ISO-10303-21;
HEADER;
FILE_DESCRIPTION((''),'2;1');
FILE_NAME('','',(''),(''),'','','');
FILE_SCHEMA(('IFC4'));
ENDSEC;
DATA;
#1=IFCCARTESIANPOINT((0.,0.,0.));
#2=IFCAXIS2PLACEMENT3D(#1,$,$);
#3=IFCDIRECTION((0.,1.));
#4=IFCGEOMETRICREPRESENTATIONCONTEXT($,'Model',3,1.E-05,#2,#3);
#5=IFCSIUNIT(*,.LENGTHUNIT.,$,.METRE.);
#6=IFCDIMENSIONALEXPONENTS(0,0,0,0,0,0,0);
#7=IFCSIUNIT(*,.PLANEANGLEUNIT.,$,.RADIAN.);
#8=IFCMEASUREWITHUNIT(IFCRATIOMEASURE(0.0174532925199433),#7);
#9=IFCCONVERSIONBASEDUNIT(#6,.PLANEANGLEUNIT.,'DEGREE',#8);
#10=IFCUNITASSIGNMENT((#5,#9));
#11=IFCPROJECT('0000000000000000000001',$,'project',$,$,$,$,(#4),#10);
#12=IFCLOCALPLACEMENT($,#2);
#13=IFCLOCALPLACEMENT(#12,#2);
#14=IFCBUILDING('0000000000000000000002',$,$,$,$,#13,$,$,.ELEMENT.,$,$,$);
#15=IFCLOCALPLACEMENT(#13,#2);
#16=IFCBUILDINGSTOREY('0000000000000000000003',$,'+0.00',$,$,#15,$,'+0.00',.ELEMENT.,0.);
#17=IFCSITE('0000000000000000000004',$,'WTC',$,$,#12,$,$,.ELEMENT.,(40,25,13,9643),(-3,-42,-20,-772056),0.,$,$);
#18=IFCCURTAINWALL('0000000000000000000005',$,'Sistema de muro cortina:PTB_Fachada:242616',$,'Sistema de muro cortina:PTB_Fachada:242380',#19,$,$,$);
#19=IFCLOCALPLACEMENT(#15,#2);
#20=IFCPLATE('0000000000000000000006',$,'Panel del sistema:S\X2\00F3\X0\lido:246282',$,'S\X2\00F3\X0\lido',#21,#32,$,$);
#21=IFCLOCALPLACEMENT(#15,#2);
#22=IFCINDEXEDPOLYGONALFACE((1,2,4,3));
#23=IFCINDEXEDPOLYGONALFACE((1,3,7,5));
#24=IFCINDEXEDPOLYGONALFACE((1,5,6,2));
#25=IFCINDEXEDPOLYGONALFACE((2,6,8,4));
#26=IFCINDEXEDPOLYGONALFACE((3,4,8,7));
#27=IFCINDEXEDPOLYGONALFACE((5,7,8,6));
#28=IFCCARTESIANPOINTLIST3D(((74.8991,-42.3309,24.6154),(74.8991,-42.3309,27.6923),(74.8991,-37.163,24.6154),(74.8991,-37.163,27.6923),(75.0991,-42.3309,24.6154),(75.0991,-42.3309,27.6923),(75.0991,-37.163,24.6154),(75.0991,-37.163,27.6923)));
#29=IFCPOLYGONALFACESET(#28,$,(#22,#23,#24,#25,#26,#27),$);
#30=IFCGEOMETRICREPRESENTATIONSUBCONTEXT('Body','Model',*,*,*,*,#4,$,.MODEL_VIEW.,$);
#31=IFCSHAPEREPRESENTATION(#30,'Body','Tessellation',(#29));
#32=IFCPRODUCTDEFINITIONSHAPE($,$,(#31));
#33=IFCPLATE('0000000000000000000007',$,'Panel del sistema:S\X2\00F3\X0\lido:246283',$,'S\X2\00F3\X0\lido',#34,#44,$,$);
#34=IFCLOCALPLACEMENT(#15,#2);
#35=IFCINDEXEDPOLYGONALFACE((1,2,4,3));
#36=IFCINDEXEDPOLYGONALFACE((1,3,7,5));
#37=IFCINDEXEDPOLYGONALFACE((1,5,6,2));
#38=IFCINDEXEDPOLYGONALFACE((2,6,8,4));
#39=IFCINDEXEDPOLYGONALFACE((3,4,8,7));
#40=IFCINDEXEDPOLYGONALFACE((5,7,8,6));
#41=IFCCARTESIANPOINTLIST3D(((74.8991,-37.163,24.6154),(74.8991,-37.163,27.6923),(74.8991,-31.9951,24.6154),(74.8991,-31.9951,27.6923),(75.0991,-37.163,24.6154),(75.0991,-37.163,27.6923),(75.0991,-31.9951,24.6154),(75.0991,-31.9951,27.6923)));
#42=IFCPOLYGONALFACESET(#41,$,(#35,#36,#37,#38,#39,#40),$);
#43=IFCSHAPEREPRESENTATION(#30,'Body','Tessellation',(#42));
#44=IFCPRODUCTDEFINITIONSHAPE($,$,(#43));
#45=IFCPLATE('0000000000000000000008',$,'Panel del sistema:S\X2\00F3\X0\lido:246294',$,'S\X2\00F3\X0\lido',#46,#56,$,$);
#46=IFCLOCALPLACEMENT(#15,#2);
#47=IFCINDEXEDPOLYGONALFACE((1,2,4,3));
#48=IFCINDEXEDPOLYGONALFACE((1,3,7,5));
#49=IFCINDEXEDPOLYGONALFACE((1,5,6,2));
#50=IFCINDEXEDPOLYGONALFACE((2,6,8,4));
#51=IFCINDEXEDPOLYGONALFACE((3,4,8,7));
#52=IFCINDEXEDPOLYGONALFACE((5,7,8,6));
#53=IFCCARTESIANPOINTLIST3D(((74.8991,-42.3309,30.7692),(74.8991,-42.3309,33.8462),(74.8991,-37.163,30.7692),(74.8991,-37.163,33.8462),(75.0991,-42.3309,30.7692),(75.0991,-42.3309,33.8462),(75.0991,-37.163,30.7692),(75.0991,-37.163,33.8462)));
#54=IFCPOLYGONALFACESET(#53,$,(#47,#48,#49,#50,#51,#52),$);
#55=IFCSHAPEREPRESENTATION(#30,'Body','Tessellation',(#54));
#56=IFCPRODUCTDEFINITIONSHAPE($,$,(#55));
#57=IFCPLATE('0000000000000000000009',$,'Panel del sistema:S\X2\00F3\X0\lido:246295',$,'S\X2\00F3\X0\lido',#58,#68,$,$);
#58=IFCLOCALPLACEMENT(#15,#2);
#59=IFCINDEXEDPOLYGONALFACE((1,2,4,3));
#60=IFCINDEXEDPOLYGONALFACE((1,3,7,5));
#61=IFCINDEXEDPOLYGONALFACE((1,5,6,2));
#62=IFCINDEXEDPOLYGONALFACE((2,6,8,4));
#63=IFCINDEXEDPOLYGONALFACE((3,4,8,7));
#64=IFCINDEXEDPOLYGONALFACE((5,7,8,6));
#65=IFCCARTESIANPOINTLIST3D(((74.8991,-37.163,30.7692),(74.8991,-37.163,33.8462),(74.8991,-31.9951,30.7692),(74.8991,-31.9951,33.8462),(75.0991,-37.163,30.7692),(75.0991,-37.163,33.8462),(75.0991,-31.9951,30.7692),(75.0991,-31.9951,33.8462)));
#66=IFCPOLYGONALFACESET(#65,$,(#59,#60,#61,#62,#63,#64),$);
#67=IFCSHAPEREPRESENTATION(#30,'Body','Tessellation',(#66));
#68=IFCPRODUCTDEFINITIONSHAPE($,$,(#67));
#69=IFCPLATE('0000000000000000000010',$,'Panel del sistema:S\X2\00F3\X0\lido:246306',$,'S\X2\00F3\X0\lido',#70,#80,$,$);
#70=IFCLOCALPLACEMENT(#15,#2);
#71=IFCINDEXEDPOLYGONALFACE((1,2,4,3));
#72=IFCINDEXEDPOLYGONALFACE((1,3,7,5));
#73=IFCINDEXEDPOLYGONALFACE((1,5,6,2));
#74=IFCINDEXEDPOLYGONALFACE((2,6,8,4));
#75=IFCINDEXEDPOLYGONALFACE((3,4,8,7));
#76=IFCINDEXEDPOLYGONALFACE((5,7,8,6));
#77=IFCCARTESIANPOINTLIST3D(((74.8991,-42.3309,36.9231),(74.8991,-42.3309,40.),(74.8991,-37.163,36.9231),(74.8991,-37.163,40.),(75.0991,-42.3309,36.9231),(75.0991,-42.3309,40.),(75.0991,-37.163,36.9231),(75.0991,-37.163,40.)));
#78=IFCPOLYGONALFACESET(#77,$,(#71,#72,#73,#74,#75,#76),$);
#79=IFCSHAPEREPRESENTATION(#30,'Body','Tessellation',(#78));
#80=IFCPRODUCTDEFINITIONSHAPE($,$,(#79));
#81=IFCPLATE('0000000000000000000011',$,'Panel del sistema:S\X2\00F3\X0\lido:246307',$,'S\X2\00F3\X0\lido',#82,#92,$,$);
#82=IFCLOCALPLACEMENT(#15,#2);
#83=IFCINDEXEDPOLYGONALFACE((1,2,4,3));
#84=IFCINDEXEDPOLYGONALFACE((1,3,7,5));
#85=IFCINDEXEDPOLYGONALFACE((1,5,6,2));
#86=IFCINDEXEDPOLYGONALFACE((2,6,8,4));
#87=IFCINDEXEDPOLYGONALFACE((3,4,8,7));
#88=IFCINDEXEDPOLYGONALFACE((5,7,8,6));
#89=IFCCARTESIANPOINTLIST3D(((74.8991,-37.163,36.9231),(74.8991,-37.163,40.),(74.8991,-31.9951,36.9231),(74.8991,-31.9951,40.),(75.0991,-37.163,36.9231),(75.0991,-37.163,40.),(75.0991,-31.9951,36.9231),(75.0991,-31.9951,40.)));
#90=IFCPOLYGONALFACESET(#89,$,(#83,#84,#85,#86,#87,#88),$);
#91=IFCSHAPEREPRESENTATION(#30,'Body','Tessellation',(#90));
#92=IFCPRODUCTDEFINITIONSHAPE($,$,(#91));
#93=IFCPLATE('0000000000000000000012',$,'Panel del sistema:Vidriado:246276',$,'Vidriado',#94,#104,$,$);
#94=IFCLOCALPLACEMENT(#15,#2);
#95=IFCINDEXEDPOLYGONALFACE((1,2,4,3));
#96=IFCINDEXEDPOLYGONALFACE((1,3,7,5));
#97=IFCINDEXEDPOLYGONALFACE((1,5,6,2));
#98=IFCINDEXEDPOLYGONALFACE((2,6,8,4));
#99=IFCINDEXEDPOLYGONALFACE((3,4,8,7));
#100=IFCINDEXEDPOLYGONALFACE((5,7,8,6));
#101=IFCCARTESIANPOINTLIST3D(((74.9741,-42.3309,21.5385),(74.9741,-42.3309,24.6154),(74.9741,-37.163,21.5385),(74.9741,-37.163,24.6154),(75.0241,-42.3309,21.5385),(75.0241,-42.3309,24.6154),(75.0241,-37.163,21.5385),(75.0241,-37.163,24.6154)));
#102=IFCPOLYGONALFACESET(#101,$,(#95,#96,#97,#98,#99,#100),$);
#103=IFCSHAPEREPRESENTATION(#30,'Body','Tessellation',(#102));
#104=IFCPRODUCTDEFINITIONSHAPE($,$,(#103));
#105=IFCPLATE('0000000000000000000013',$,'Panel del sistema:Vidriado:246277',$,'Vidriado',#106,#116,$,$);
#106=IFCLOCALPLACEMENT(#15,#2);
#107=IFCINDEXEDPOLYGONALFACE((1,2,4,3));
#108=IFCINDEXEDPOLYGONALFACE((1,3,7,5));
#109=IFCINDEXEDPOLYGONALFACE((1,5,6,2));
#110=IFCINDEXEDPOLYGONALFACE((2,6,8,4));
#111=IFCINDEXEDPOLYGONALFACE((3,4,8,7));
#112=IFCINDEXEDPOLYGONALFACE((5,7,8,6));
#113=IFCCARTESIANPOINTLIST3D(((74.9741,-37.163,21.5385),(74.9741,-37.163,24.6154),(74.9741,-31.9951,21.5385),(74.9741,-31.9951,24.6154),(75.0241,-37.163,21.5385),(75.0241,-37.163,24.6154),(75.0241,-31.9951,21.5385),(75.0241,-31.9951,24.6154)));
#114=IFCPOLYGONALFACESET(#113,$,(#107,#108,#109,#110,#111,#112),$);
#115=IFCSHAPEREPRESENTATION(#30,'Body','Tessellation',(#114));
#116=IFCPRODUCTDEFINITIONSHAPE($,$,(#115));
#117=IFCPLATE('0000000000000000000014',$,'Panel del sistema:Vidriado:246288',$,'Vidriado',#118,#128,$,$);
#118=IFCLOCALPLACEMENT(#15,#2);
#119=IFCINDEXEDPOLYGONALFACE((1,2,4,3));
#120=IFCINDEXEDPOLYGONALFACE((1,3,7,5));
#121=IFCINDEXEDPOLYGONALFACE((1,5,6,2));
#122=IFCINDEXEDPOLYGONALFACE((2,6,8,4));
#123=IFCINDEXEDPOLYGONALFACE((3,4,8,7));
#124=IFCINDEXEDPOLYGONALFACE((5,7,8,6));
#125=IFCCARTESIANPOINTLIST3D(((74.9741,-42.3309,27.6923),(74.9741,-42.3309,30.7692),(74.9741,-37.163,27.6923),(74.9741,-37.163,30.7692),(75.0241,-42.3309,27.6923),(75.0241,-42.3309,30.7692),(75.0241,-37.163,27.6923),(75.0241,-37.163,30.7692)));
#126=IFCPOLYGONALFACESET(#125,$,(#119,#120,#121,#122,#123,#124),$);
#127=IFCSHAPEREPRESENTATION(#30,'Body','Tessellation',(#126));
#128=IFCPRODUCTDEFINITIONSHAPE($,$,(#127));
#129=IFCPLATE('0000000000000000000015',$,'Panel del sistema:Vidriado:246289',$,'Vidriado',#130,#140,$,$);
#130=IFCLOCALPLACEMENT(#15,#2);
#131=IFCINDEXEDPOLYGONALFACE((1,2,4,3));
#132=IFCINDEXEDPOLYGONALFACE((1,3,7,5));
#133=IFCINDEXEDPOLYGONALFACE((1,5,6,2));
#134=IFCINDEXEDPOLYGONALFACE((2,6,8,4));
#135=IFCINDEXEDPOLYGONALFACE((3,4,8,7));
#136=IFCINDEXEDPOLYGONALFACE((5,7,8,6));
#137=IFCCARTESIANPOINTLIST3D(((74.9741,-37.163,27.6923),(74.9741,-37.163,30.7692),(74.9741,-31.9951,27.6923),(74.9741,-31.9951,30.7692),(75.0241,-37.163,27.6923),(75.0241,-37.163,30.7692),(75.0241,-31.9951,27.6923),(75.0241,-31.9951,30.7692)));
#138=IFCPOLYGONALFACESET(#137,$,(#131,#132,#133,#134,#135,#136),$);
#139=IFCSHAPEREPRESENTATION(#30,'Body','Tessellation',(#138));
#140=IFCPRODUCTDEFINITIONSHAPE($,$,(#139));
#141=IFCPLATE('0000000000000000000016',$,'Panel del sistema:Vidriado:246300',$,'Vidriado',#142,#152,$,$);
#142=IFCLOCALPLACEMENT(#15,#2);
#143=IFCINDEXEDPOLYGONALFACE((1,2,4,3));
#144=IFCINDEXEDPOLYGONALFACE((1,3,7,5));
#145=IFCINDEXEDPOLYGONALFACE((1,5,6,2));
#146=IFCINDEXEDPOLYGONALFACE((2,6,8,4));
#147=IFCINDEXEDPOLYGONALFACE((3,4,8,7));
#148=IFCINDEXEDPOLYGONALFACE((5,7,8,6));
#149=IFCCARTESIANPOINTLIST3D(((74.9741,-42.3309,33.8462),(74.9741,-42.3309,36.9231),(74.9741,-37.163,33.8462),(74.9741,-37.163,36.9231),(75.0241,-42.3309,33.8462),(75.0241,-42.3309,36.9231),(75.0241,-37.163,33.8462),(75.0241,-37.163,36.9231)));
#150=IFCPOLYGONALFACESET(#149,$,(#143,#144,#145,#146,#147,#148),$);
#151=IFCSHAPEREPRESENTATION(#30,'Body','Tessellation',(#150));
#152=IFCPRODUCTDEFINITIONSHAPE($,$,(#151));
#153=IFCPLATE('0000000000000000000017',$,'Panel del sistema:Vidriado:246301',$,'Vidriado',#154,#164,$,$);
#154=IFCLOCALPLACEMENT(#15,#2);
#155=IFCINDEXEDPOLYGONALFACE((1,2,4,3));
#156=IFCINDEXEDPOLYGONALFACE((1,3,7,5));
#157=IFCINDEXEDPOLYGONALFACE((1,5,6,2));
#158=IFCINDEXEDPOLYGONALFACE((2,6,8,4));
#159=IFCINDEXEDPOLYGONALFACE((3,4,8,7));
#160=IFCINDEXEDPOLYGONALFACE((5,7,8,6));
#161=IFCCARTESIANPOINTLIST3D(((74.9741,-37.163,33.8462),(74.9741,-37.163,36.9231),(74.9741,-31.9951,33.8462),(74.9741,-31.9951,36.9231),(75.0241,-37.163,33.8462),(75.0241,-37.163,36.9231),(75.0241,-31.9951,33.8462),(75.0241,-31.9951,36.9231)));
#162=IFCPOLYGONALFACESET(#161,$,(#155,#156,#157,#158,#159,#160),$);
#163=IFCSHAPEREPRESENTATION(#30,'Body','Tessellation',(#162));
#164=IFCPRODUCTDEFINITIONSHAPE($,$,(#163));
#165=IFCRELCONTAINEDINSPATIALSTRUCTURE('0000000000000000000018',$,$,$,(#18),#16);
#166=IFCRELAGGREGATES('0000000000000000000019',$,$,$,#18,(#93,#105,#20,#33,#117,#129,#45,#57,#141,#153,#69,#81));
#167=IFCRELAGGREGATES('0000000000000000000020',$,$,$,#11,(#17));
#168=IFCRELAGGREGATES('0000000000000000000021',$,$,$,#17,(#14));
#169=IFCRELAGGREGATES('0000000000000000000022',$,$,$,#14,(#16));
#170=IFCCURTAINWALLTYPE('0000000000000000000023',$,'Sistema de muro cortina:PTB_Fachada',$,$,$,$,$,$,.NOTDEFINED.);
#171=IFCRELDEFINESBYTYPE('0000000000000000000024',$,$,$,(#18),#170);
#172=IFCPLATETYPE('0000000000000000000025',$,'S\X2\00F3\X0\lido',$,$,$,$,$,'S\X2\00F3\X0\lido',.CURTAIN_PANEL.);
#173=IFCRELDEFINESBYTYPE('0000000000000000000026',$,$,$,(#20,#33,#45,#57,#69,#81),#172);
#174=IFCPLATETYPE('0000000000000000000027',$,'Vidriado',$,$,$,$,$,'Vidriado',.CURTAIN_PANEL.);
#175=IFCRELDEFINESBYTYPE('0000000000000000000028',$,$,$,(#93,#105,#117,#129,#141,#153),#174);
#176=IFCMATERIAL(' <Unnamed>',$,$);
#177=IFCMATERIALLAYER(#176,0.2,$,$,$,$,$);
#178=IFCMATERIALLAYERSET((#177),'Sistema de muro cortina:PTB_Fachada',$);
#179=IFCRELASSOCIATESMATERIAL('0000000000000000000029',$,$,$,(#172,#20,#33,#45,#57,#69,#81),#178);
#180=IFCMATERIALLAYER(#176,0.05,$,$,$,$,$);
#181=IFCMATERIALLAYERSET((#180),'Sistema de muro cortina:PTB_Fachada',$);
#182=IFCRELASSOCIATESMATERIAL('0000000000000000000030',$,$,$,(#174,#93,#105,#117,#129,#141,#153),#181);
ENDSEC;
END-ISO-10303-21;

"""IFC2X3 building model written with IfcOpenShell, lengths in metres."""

from ifc_helpers import new_model, entity, si_unit, converted_unit, direction, frame, origin, origin_2d_with_axis, place, context, subcontext, project, spatial, rectangle, extrude, source, transform, mapped, material, layer, layer_set, layer_usage, type_object, type_shapes, element, aggregate, save


model = new_model("IFC2X3")

# Units and contexts
model_context = context("Model", 3, precision=1e-05, world=origin(), true_north=direction((0.0, 1.0)))
body_context = subcontext(model_context, "Body", "Model", "MODEL_VIEW")
ifc_project = project(units=[si_unit("LENGTHUNIT", "METRE"), converted_unit("PLANEANGLEUNIT", "DEGREE", entity("IfcRatioMeasure", 0.0174532925199433), si_unit("PLANEANGLEUNIT", "RADIAN"), dimensions=[0, 0, 0, 0, 0, 0, 0])], contexts=[model_context])

# Site, building, storey
site_placement = place(None, origin())
site = spatial("IfcSite", under=ifc_project, at=site_placement, Name="WTC", CompositionType="ELEMENT", RefLatitude=(40, 25, 13, 9643), RefLongitude=(-3, -42, -20, -772056), RefElevation=0.0)
building_placement = place(site_placement, origin())
building = spatial("IfcBuilding", under=site, at=building_placement, CompositionType="ELEMENT")
storey_placement = place(building_placement, origin())
storey = spatial("IfcBuildingStorey", under=building, at=storey_placement, Name="+0.00", LongName="+0.00", CompositionType="ELEMENT", Elevation=0.0)

# Curtain wall, plates
curtain_wall_type = type_object("IfcCurtainWallType", Name="Sistema de muro cortina:PTB_Fachada", PredefinedType="NOTDEFINED")
ifc_material = material(Name=" <Unnamed>")
ifc_layer_1 = layer(ifc_material, 0.2)
ifc_layer_set_1 = layer_set([ifc_layer_1], Name="Sistema de muro cortina:PTB_Fachada")
ifc_layer_2 = layer(ifc_material, 0.05)
ifc_layer_set_2 = layer_set([ifc_layer_2], Name="Sistema de muro cortina:PTB_Fachada")
curtain_wall_1_placement = place(storey_placement, origin())
curtain_wall_1 = element("IfcCurtainWall", 1, at=curtain_wall_1_placement, inside=storey, type_object=curtain_wall_type, Name="Sistema de muro cortina:PTB_Fachada:242616", ObjectType="Sistema de muro cortina:PTB_Fachada:242380")
ifc_layer_usage_1 = layer_usage(ifc_layer_set_1, "AXIS3", "POSITIVE", 0.0)
plate_type_1 = type_object("IfcPlateType", Name="Sólido", ElementType="Sólido", PredefinedType="CURTAIN_PANEL", material=ifc_layer_set_1)
shared_shape_1 = source(origin(), body_context, "Body", "SweptSolid", [
    extrude(rectangle(XDim=0.2, YDim=5.1679, at=origin_2d_with_axis()), frame((0.0, 0.0, 0.0), z_axis=(0.0, 0.0, 1.0), x_axis=(0.0, 1.0, 0.0)), (0.0, 0.0, 1.0), 3.0769),
])
type_shapes(plate_type_1, [shared_shape_1])
plate_1_placement = place(curtain_wall_1_placement, frame((74.9991, -39.747, 24.6154), z_axis=(0.0, 0.0, 1.0), x_axis=(0.0, 1.0, 0.0)))
plate_1 = element("IfcPlate", 2, at=plate_1_placement, type_object=plate_type_1, material=ifc_layer_usage_1, Name="Panel del sistema:Sólido:246282", ObjectType="Sólido", context=body_context, shape_type="MappedRepresentation", body=[
    mapped(shared_shape_1, transform((0.0, 0.0, 0.0), scale=1.0)),
])
ifc_layer_usage_2 = layer_usage(ifc_layer_set_1, "AXIS3", "POSITIVE", 0.0)
plate_2_placement = place(curtain_wall_1_placement, frame((74.9991, -34.5791, 24.6154), z_axis=(0.0, 0.0, 1.0), x_axis=(0.0, 1.0, 0.0)))
plate_2 = element("IfcPlate", 3, at=plate_2_placement, type_object=plate_type_1, material=ifc_layer_usage_2, Name="Panel del sistema:Sólido:246283", ObjectType="Sólido", context=body_context, shape_type="MappedRepresentation", body=[
    mapped(shared_shape_1, transform((0.0, 0.0, 0.0), scale=1.0)),
])
ifc_layer_usage_3 = layer_usage(ifc_layer_set_1, "AXIS3", "POSITIVE", 0.0)
plate_3_placement = place(curtain_wall_1_placement, frame((74.9991, -39.747, 30.7692), z_axis=(0.0, 0.0, 1.0), x_axis=(0.0, 1.0, 0.0)))
plate_3 = element("IfcPlate", 4, at=plate_3_placement, type_object=plate_type_1, material=ifc_layer_usage_3, Name="Panel del sistema:Sólido:246294", ObjectType="Sólido", context=body_context, shape_type="MappedRepresentation", body=[
    mapped(shared_shape_1, transform((0.0, 0.0, 0.0), scale=1.0)),
])
ifc_layer_usage_4 = layer_usage(ifc_layer_set_1, "AXIS3", "POSITIVE", 0.0)
plate_4_placement = place(curtain_wall_1_placement, frame((74.9991, -34.5791, 30.7692), z_axis=(0.0, 0.0, 1.0), x_axis=(0.0, 1.0, 0.0)))
plate_4 = element("IfcPlate", 5, at=plate_4_placement, type_object=plate_type_1, material=ifc_layer_usage_4, Name="Panel del sistema:Sólido:246295", ObjectType="Sólido", context=body_context, shape_type="MappedRepresentation", body=[
    mapped(shared_shape_1, transform((0.0, 0.0, 0.0), scale=1.0)),
])
ifc_layer_usage_5 = layer_usage(ifc_layer_set_1, "AXIS3", "POSITIVE", 0.0)
plate_5_placement = place(curtain_wall_1_placement, frame((74.9991, -39.747, 36.9231), z_axis=(0.0, 0.0, 1.0), x_axis=(0.0, 1.0, 0.0)))
plate_5 = element("IfcPlate", 6, at=plate_5_placement, type_object=plate_type_1, material=ifc_layer_usage_5, Name="Panel del sistema:Sólido:246306", ObjectType="Sólido", context=body_context, shape_type="MappedRepresentation", body=[
    mapped(shared_shape_1, transform((0.0, 0.0, 0.0), scale=1.0)),
])
ifc_layer_usage_6 = layer_usage(ifc_layer_set_1, "AXIS3", "POSITIVE", 0.0)
plate_6_placement = place(curtain_wall_1_placement, frame((74.9991, -34.5791, 36.9231), z_axis=(0.0, 0.0, 1.0), x_axis=(0.0, 1.0, 0.0)))
plate_6 = element("IfcPlate", 7, at=plate_6_placement, type_object=plate_type_1, material=ifc_layer_usage_6, Name="Panel del sistema:Sólido:246307", ObjectType="Sólido", context=body_context, shape_type="MappedRepresentation", body=[
    mapped(shared_shape_1, transform((0.0, 0.0, 0.0), scale=1.0)),
])
ifc_layer_usage_7 = layer_usage(ifc_layer_set_2, "AXIS3", "POSITIVE", 0.0)
plate_type_2 = type_object("IfcPlateType", Name="Vidriado", ElementType="Vidriado", PredefinedType="CURTAIN_PANEL", material=ifc_layer_set_2)
shared_shape_2 = source(origin(), body_context, "Body", "SweptSolid", [
    extrude(rectangle(XDim=0.05, YDim=5.1679, at=origin_2d_with_axis()), frame((0.0, 0.0, 0.0), z_axis=(0.0, 0.0, 1.0), x_axis=(0.0, 1.0, 0.0)), (0.0, 0.0, 1.0), 3.0769),
])
type_shapes(plate_type_2, [shared_shape_2])
plate_7_placement = place(curtain_wall_1_placement, frame((74.9991, -39.747, 21.5385), z_axis=(0.0, 0.0, 1.0), x_axis=(0.0, 1.0, 0.0)))
plate_7 = element("IfcPlate", 8, at=plate_7_placement, type_object=plate_type_2, material=ifc_layer_usage_7, Name="Panel del sistema:Vidriado:246276", ObjectType="Vidriado", context=body_context, shape_type="MappedRepresentation", body=[
    mapped(shared_shape_2, transform((0.0, 0.0, 0.0), scale=1.0)),
])
ifc_layer_usage_8 = layer_usage(ifc_layer_set_2, "AXIS3", "POSITIVE", 0.0)
plate_8_placement = place(curtain_wall_1_placement, frame((74.9991, -34.5791, 21.5385), z_axis=(0.0, 0.0, 1.0), x_axis=(0.0, 1.0, 0.0)))
plate_8 = element("IfcPlate", 9, at=plate_8_placement, type_object=plate_type_2, material=ifc_layer_usage_8, Name="Panel del sistema:Vidriado:246277", ObjectType="Vidriado", context=body_context, shape_type="MappedRepresentation", body=[
    mapped(shared_shape_2, transform((0.0, 0.0, 0.0), scale=1.0)),
])
ifc_layer_usage_9 = layer_usage(ifc_layer_set_2, "AXIS3", "POSITIVE", 0.0)
plate_9_placement = place(curtain_wall_1_placement, frame((74.9991, -39.747, 27.6923), z_axis=(0.0, 0.0, 1.0), x_axis=(0.0, 1.0, 0.0)))
plate_9 = element("IfcPlate", 10, at=plate_9_placement, type_object=plate_type_2, material=ifc_layer_usage_9, Name="Panel del sistema:Vidriado:246288", ObjectType="Vidriado", context=body_context, shape_type="MappedRepresentation", body=[
    mapped(shared_shape_2, transform((0.0, 0.0, 0.0), scale=1.0)),
])
ifc_layer_usage_10 = layer_usage(ifc_layer_set_2, "AXIS3", "POSITIVE", 0.0)
plate_10_placement = place(curtain_wall_1_placement, frame((74.9991, -34.5791, 27.6923), z_axis=(0.0, 0.0, 1.0), x_axis=(0.0, 1.0, 0.0)))
plate_10 = element("IfcPlate", 11, at=plate_10_placement, type_object=plate_type_2, material=ifc_layer_usage_10, Name="Panel del sistema:Vidriado:246289", ObjectType="Vidriado", context=body_context, shape_type="MappedRepresentation", body=[
    mapped(shared_shape_2, transform((0.0, 0.0, 0.0), scale=1.0)),
])
ifc_layer_usage_11 = layer_usage(ifc_layer_set_2, "AXIS3", "POSITIVE", 0.0)
plate_11_placement = place(curtain_wall_1_placement, frame((74.9991, -39.747, 33.8462), z_axis=(0.0, 0.0, 1.0), x_axis=(0.0, 1.0, 0.0)))
plate_11 = element("IfcPlate", 12, at=plate_11_placement, type_object=plate_type_2, material=ifc_layer_usage_11, Name="Panel del sistema:Vidriado:246300", ObjectType="Vidriado", context=body_context, shape_type="MappedRepresentation", body=[
    mapped(shared_shape_2, transform((0.0, 0.0, 0.0), scale=1.0)),
])
ifc_layer_usage_12 = layer_usage(ifc_layer_set_2, "AXIS3", "POSITIVE", 0.0)
plate_12_placement = place(curtain_wall_1_placement, frame((74.9991, -34.5791, 33.8462), z_axis=(0.0, 0.0, 1.0), x_axis=(0.0, 1.0, 0.0)))
plate_12 = element("IfcPlate", 13, at=plate_12_placement, type_object=plate_type_2, material=ifc_layer_usage_12, Name="Panel del sistema:Vidriado:246301", ObjectType="Vidriado", context=body_context, shape_type="MappedRepresentation", body=[
    mapped(shared_shape_2, transform((0.0, 0.0, 0.0), scale=1.0)),
])
aggregate(curtain_wall_1, [plate_7, plate_8, plate_1, plate_2, plate_9, plate_10, plate_3, plate_4, plate_11, plate_12, plate_5, plate_6])

save(model, "model.ifc")
